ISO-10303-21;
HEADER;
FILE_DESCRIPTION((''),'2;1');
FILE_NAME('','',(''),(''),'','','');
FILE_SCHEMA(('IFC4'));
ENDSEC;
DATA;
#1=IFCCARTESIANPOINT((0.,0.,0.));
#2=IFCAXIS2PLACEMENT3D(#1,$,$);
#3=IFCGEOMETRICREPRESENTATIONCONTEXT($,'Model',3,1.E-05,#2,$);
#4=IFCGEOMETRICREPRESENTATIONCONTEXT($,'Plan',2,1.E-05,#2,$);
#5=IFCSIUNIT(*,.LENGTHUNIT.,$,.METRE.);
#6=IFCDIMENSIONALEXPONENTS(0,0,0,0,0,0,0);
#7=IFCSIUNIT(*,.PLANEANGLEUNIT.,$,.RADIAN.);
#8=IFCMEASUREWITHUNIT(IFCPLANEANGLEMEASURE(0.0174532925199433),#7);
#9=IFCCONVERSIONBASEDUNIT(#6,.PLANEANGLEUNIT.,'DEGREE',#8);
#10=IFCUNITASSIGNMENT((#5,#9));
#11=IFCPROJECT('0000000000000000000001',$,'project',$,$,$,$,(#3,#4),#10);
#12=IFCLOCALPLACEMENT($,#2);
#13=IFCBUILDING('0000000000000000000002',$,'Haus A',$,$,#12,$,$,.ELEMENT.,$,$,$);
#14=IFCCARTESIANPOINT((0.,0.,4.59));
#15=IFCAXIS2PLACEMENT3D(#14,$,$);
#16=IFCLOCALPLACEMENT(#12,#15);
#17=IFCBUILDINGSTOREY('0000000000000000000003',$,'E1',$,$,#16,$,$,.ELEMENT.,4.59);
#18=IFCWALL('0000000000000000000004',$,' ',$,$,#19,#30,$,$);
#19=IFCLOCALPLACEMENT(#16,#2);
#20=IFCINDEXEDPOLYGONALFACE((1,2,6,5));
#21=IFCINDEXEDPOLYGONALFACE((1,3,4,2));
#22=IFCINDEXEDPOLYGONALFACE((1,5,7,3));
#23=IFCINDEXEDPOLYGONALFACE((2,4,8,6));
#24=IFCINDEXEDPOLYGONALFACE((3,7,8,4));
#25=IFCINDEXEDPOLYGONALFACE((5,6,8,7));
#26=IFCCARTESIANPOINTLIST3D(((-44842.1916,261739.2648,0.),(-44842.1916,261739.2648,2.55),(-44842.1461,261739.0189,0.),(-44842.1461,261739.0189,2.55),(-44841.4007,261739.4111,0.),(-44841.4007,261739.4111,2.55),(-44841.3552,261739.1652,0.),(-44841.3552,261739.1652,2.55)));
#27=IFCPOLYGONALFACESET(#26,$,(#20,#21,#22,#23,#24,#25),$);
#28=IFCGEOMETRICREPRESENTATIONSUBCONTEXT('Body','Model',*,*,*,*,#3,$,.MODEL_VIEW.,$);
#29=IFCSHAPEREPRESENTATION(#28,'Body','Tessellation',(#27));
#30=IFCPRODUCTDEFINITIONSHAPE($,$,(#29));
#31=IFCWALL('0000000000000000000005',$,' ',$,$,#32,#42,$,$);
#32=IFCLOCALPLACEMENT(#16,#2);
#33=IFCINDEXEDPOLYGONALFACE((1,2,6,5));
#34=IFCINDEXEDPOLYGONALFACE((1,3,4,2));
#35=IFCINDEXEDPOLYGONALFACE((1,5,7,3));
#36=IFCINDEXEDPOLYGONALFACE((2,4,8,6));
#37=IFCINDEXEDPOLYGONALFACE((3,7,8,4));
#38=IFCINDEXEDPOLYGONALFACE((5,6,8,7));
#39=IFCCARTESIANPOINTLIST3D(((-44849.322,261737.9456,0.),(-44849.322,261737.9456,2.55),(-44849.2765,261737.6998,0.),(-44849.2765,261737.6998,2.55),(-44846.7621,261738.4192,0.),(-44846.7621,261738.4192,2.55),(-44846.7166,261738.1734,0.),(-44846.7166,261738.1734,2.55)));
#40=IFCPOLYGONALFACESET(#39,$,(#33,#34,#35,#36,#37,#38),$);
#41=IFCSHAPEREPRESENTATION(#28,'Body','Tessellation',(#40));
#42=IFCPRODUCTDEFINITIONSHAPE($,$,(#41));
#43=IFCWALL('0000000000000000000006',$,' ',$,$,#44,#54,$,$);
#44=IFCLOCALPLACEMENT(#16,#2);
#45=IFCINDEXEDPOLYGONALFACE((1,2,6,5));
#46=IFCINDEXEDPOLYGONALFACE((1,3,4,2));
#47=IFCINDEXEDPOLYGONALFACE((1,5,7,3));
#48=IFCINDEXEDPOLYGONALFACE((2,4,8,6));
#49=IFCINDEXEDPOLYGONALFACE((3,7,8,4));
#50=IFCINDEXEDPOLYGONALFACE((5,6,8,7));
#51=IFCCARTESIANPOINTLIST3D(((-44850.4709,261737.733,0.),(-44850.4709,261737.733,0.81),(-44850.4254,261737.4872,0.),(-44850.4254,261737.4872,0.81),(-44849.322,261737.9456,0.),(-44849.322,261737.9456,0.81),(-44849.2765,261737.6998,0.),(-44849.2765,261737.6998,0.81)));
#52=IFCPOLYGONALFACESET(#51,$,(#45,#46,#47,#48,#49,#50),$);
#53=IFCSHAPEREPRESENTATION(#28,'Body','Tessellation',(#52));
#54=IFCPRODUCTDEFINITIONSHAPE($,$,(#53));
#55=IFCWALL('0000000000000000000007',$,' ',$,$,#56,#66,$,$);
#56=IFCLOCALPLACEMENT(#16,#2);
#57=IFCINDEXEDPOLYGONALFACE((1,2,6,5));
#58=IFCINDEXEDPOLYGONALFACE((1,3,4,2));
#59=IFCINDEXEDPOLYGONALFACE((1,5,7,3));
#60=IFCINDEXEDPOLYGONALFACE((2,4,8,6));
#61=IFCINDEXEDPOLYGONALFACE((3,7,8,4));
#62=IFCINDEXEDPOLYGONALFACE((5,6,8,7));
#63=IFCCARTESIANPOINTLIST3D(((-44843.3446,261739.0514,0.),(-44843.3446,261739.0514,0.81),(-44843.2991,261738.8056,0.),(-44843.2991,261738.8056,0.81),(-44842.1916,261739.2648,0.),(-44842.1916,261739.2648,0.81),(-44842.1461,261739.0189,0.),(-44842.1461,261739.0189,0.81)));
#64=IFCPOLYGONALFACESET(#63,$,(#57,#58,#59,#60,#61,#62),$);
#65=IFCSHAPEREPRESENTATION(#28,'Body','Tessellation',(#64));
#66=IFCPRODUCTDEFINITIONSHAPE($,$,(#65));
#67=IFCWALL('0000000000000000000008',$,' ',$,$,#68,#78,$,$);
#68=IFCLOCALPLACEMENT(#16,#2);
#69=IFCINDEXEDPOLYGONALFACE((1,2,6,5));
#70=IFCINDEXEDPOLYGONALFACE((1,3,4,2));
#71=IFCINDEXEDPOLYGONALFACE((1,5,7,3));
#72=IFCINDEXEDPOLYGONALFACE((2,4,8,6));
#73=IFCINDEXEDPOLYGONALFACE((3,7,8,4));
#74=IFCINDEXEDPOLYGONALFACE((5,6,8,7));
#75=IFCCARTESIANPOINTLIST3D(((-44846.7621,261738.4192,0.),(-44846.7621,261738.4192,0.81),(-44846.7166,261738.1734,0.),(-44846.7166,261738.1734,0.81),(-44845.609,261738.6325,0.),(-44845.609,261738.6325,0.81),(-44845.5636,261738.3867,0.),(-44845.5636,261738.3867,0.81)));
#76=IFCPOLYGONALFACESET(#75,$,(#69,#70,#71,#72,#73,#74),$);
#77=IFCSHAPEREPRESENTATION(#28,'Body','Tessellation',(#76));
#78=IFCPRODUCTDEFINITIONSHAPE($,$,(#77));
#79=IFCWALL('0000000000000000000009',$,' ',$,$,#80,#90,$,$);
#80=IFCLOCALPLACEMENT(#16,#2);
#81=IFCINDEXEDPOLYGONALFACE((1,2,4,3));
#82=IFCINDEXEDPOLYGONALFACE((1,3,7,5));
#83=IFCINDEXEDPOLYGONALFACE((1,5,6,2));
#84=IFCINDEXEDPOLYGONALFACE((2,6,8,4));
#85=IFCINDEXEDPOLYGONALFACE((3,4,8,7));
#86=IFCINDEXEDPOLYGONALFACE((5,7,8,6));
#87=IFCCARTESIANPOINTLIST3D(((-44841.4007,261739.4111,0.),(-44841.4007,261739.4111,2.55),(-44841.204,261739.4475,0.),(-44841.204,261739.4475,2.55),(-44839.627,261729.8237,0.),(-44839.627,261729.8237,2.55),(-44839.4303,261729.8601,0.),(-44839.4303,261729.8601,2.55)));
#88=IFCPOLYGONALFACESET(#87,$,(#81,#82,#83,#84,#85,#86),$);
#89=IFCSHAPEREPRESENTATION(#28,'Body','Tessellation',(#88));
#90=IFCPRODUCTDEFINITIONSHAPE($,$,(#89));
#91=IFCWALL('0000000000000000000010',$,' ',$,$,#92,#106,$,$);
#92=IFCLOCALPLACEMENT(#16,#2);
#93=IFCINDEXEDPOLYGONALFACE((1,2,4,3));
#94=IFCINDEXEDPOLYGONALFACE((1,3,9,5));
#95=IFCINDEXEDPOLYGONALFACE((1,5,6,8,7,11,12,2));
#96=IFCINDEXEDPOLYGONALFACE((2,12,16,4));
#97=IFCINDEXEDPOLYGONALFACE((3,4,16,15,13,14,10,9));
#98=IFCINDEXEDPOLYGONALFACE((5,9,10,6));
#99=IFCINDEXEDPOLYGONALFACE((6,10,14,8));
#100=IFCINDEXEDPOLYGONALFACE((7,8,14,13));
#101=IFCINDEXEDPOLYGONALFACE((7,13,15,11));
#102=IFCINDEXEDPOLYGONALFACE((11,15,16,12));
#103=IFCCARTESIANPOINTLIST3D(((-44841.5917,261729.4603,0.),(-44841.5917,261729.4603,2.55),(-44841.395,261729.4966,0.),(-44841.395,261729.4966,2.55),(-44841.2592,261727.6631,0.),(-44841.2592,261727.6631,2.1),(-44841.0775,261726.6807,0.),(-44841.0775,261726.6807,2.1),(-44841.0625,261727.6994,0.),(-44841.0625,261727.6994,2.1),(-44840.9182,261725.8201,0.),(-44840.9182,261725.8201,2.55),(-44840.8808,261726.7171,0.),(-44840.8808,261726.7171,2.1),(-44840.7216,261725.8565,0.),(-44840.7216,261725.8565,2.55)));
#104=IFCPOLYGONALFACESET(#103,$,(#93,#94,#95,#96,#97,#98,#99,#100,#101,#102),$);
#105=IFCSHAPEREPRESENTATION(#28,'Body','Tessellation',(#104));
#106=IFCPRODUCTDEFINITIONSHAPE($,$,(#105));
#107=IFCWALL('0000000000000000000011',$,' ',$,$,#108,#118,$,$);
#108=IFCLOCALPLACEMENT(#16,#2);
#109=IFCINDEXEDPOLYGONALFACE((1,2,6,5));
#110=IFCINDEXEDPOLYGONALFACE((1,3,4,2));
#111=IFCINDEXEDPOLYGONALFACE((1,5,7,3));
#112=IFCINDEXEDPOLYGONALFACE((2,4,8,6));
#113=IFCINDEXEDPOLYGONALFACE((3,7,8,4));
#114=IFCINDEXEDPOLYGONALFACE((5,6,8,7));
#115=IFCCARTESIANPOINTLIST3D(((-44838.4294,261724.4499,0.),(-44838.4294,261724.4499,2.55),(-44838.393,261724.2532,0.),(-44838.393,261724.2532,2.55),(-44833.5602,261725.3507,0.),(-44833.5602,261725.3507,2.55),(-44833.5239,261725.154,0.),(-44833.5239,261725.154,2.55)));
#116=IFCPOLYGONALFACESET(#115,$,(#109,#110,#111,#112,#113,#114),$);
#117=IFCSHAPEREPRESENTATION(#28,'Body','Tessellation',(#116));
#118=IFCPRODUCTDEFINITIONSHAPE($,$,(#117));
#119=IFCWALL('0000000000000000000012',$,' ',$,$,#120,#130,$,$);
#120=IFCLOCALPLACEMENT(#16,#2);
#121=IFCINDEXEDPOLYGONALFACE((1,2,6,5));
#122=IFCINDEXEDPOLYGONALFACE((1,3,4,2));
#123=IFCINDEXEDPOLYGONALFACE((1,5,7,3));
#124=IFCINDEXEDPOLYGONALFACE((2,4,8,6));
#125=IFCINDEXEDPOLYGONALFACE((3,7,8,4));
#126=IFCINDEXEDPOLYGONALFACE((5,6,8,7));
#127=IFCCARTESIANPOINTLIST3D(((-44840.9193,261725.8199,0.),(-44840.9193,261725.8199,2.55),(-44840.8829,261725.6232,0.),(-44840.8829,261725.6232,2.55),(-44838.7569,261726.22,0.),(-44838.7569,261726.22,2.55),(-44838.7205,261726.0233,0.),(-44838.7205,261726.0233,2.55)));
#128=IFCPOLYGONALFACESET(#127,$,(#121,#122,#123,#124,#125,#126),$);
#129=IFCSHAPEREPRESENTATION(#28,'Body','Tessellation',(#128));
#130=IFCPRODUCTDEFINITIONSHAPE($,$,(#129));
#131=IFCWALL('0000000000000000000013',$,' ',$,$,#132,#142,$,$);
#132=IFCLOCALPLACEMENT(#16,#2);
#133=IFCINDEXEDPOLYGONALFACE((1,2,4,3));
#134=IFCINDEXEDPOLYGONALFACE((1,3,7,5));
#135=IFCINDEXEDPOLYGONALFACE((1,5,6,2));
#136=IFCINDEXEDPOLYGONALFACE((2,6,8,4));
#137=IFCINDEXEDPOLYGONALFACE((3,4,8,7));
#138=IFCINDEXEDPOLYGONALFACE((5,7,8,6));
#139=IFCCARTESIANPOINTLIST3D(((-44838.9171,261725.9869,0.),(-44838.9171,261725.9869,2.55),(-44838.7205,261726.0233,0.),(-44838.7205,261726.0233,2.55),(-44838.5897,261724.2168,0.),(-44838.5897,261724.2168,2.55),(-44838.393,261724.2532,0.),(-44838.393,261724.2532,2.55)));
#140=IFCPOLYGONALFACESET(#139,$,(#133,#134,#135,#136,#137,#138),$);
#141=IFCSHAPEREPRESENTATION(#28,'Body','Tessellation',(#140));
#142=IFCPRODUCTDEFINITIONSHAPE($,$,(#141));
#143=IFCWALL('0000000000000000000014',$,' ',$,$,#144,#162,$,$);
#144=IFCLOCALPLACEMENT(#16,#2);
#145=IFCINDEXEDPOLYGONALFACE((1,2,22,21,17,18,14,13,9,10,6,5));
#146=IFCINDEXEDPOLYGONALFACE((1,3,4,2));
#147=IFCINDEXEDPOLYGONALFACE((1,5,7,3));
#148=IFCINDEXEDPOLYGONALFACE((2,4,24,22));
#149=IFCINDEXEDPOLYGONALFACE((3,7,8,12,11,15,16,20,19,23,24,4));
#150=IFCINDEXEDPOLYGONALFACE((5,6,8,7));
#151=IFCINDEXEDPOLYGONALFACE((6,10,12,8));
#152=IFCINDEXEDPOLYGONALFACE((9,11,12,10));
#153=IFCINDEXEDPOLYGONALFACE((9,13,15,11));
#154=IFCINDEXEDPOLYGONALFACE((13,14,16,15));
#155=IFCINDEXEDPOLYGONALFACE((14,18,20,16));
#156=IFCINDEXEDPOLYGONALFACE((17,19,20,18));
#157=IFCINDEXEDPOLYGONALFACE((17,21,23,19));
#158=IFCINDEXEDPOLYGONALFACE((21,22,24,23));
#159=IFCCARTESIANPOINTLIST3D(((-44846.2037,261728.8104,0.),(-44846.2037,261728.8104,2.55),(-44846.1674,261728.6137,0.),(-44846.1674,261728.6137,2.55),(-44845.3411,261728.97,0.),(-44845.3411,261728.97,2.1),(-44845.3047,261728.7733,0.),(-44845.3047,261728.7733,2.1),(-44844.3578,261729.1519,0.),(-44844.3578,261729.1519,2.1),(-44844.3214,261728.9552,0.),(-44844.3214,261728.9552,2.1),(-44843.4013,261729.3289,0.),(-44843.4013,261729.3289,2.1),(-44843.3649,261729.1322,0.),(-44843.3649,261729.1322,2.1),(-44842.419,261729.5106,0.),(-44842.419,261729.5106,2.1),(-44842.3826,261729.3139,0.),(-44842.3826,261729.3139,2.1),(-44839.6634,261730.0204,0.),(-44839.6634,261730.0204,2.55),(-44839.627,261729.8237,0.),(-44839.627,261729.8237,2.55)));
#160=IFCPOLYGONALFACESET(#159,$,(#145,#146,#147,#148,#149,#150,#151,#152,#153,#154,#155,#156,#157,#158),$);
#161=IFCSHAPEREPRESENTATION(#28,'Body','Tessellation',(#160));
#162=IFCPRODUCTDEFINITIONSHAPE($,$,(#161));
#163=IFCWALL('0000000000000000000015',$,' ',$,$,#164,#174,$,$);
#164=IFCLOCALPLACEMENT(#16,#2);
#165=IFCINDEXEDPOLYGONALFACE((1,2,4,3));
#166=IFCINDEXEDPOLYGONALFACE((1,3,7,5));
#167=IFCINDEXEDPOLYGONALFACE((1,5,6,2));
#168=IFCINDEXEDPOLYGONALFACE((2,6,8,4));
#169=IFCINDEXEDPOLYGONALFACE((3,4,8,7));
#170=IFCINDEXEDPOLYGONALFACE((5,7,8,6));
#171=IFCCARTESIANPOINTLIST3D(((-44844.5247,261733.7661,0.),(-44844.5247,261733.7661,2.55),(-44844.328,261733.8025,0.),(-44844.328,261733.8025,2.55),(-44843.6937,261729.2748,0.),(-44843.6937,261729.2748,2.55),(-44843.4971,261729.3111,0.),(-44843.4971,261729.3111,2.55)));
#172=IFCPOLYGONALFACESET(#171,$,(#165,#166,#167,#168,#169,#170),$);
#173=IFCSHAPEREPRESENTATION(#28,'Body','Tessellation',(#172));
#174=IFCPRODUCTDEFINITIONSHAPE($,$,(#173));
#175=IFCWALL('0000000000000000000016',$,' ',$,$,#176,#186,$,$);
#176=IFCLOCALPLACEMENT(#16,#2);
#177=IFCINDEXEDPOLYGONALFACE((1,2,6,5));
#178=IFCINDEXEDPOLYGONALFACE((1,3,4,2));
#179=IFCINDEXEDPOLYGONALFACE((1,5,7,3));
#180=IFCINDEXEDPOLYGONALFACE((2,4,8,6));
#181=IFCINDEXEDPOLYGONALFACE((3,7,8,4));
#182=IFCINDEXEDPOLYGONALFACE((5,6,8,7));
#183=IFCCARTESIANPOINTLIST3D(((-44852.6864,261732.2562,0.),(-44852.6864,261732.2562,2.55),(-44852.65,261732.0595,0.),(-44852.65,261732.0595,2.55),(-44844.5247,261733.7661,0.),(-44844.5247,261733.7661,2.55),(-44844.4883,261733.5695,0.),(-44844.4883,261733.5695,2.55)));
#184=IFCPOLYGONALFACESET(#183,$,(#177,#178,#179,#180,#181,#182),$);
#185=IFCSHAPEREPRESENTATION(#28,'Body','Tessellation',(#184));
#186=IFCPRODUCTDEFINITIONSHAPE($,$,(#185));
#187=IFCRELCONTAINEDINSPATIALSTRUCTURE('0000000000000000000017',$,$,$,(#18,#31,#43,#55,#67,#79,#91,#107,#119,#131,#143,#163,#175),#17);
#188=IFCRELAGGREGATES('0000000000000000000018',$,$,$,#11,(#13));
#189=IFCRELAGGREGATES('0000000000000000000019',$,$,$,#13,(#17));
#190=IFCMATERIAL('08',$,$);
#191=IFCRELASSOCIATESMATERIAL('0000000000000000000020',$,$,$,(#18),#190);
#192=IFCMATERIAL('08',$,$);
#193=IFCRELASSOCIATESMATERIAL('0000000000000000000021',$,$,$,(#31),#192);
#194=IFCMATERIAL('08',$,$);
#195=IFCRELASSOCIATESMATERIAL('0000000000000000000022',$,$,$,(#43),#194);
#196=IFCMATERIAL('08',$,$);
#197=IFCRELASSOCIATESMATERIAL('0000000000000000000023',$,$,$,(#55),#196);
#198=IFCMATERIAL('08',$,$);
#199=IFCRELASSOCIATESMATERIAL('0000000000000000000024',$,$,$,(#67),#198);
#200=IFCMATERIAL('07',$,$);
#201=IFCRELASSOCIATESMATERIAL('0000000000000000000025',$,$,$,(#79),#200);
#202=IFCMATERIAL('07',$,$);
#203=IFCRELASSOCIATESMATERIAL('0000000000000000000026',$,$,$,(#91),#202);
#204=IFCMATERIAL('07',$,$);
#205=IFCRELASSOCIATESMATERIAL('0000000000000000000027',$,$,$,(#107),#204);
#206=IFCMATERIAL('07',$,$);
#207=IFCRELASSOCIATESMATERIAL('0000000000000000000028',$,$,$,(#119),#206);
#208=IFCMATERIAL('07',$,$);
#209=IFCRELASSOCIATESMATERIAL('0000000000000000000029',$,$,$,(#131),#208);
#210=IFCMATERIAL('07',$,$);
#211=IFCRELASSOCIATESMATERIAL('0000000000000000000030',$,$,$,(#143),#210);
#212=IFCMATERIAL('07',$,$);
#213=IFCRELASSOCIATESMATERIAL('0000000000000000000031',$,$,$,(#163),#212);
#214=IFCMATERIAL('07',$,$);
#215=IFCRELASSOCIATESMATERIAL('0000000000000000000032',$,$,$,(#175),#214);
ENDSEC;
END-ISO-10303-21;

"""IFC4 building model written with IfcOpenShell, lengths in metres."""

from ifc_helpers import new_model, entity, si_unit, converted_unit, frame, frame_2d, origin, origin_with_axes, place, context, subcontext, project, spatial, polyline, rectangle, outline, extrude, material, element, save


model = new_model("IFC4")

# Units and contexts
model_context = context("Model", 3, precision=1e-05, world=origin())
plan_context = context("Plan", 2, precision=1e-05, world=origin())
body_context = subcontext(model_context, "Body", "Model", "MODEL_VIEW")
ifc_project = project(units=[si_unit("LENGTHUNIT", "METRE"), converted_unit("PLANEANGLEUNIT", "DEGREE", entity("IfcPlaneAngleMeasure", 0.0174532925199433), si_unit("PLANEANGLEUNIT", "RADIAN"), dimensions=[0, 0, 0, 0, 0, 0, 0])], contexts=[model_context, plan_context])

# Building, storey
building_placement = place(None, origin())
building = spatial("IfcBuilding", under=ifc_project, at=building_placement, Name="Haus A", CompositionType="ELEMENT")
storey_placement = place(building_placement, frame((0.0, 0.0, 4.59)))
storey = spatial("IfcBuildingStorey", under=building, at=storey_placement, Name="E1", CompositionType="ELEMENT", Elevation=4.59)

# Walls
ifc_material_1 = material(Name="08")
wall_1_placement = place(storey_placement, frame((-44841.4007, 261739.4111, 0.0), z_axis=(0.0, 0.0, 1.0), x_axis=(-0.983313, -0.18192, 0.0)))
element("IfcWall", 1, at=wall_1_placement, inside=storey, material=ifc_material_1, Name=" ", context=body_context, shape_type="SweptSolid", body=[
    extrude(rectangle(XDim=0.8043, YDim=0.25, at=frame_2d((0.4022, 0.125), x_axis=(1.0, 0.0))), origin_with_axes(), (0.0, 0.0, 1.0), 2.55),
])
ifc_material_2 = material(Name="08")
wall_2_placement = place(storey_placement, frame((-44846.7621, 261738.4192, 0.0), z_axis=(0.0, 0.0, 1.0), x_axis=(-0.983313, -0.18192, 0.0)))
element("IfcWall", 2, at=wall_2_placement, inside=storey, material=ifc_material_2, Name=" ", context=body_context, shape_type="SweptSolid", body=[
    extrude(rectangle(XDim=2.6034, YDim=0.25, at=frame_2d((1.3017, 0.125), x_axis=(1.0, 0.0))), origin_with_axes(), (0.0, 0.0, 1.0), 2.55),
])
ifc_material_3 = material(Name="08")
wall_3_placement = place(storey_placement, frame((-44849.322, 261737.9456, 0.0), z_axis=(0.0, 0.0, 1.0), x_axis=(-0.983313, -0.18192, 0.0)))
element("IfcWall", 3, at=wall_3_placement, inside=storey, material=ifc_material_3, Name=" ", context=body_context, shape_type="SweptSolid", body=[
    extrude(rectangle(XDim=1.1684, YDim=0.25, at=frame_2d((0.5842, 0.125), x_axis=(1.0, 0.0))), origin_with_axes(), (0.0, 0.0, 1.0), 0.81),
])
ifc_material_4 = material(Name="08")
wall_4_placement = place(storey_placement, frame((-44842.1916, 261739.2648, 0.0), z_axis=(0.0, 0.0, 1.0), x_axis=(-0.983313, -0.18192, 0.0)))
element("IfcWall", 4, at=wall_4_placement, inside=storey, material=ifc_material_4, Name=" ", context=body_context, shape_type="SweptSolid", body=[
    extrude(rectangle(XDim=1.1726, YDim=0.25, at=frame_2d((0.5863, 0.125), x_axis=(1.0, 0.0))), origin_with_axes(), (0.0, 0.0, 1.0), 0.81),
])
ifc_material_5 = material(Name="08")
wall_5_placement = place(storey_placement, frame((-44845.609, 261738.6325, 0.0), z_axis=(0.0, 0.0, 1.0), x_axis=(-0.983313, -0.18192, 0.0)))
element("IfcWall", 5, at=wall_5_placement, inside=storey, material=ifc_material_5, Name=" ", context=body_context, shape_type="SweptSolid", body=[
    extrude(rectangle(XDim=1.1726, YDim=0.25, at=frame_2d((0.5863, 0.125), x_axis=(1.0, 0.0))), origin_with_axes(), (0.0, 0.0, 1.0), 0.81),
])
ifc_material_6 = material(Name="07")
wall_6_placement = place(storey_placement, frame((-44841.4007, 261739.4111, 0.0), z_axis=(0.0, 0.0, 1.0), x_axis=(0.18192, -0.983313, 0.0)))
element("IfcWall", 6, at=wall_6_placement, inside=storey, material=ifc_material_6, Name=" ", context=body_context, shape_type="SweptSolid", body=[
    extrude(rectangle(XDim=9.75, YDim=0.2, at=frame_2d((4.875, 0.1), x_axis=(1.0, 0.0))), origin_with_axes(), (0.0, 0.0, 1.0), 2.55),
])

# Wall, opening
ifc_material_7 = material(Name="07")
wall_7_placement = place(storey_placement, frame((-44841.5917, 261729.4603, 0.0), z_axis=(0.0, 0.0, 1.0), x_axis=(0.18192, -0.983313, 0.0)))
wall_7 = element("IfcWall", 7, at=wall_7_placement, inside=storey, material=ifc_material_7, Name=" ", context=body_context, shape_type="SweptSolid", body=[
    extrude(rectangle(XDim=3.7019, YDim=0.2, at=frame_2d((1.851, 0.1), x_axis=(1.0, 0.0))), origin_with_axes(), (0.0, 0.0, 1.0), 2.55),
])
opening_1_placement = place(wall_7_placement, frame((2.8267, 0.2, 0.0), z_axis=(0.0, -1.0, 0.0), x_axis=(0.0, 0.0, 1.0)))
element("IfcOpeningElement", 8, at=opening_1_placement, cuts=wall_7, ObjectType="Opening", context=body_context, shape_type="SweptSolid", body=[
    extrude(outline(polyline([(0.0, 0.999), (2.1, 0.999), (2.1, 0.0), (0.0, 0.0), (0.0, 0.999)])), origin_with_axes(), (0.0, 0.0, 1.0), 0.2),
])

# Walls
ifc_material_8 = material(Name="07")
wall_8_placement = place(storey_placement, frame((-44833.5602, 261725.3507, 0.0), z_axis=(0.0, 0.0, 1.0), x_axis=(-0.983313, -0.18192, 0.0)))
element("IfcWall", 9, at=wall_8_placement, inside=storey, material=ifc_material_8, Name=" ", context=body_context, shape_type="SweptSolid", body=[
    extrude(rectangle(XDim=4.9518, YDim=0.2, at=frame_2d((2.4759, 0.1), x_axis=(1.0, 0.0))), origin_with_axes(), (0.0, 0.0, 1.0), 2.55),
])
ifc_material_9 = material(Name="07")
wall_9_placement = place(storey_placement, frame((-44840.8829, 261725.6232, 0.0), z_axis=(0.0, 0.0, 1.0), x_axis=(0.983313, 0.18192, 0.0)))
element("IfcWall", 10, at=wall_9_placement, inside=storey, material=ifc_material_9, Name=" ", context=body_context, shape_type="SweptSolid", body=[
    extrude(rectangle(XDim=2.1991, YDim=0.2, at=frame_2d((1.0995, 0.1), x_axis=(1.0, 0.0))), origin_with_axes(), (0.0, 0.0, 1.0), 2.55),
])
ifc_material_10 = material(Name="07")
wall_10_placement = place(storey_placement, frame((-44838.9171, 261725.9869, 0.0), z_axis=(0.0, 0.0, 1.0), x_axis=(0.18192, -0.983313, 0.0)))
element("IfcWall", 11, at=wall_10_placement, inside=storey, material=ifc_material_10, Name=" ", context=body_context, shape_type="SweptSolid", body=[
    extrude(rectangle(XDim=1.8001, YDim=0.2, at=frame_2d((0.9001, 0.1), x_axis=(1.0, 0.0))), origin_with_axes(), (0.0, 0.0, 1.0), 2.55),
])

# Wall, openings
ifc_material_11 = material(Name="07")
wall_11_placement = place(storey_placement, frame((-44839.6634, 261730.0204, 0.0), z_axis=(0.0, 0.0, 1.0), x_axis=(-0.983313, -0.18192, 0.0)))
wall_11 = element("IfcWall", 12, at=wall_11_placement, inside=storey, material=ifc_material_11, Name=" ", context=body_context, shape_type="SweptSolid", body=[
    extrude(rectangle(XDim=6.6514, YDim=0.2, at=frame_2d((3.3257, 0.1), x_axis=(1.0, 0.0))), origin_with_axes(), (0.0, 0.0, 1.0), 2.55),
])
opening_2_placement = place(wall_11_placement, frame((2.8023, 0.0, 0.0), z_axis=(0.0, 1.0, 0.0), x_axis=(0.0, 0.0, 1.0)))
element("IfcOpeningElement", 13, at=opening_2_placement, cuts=wall_11, ObjectType="Opening", context=body_context, shape_type="SweptSolid", body=[
    extrude(outline(polyline([(0.0, 0.999), (2.1, 0.999), (2.1, 0.0), (0.0, 0.0), (0.0, 0.999)])), origin_with_axes(), (0.0, 0.0, 1.0), 0.2),
])
opening_3_placement = place(wall_11_placement, frame((4.774, 0.0, 0.0), z_axis=(0.0, 1.0, 0.0), x_axis=(0.0, 0.0, 1.0)))
element("IfcOpeningElement", 14, at=opening_3_placement, cuts=wall_11, ObjectType="Opening", context=body_context, shape_type="SweptSolid", body=[
    extrude(outline(polyline([(0.0, 0.0), (0.0, 1.0), (2.1, 1.0), (2.1, 0.0), (0.0, 0.0)])), origin_with_axes(), (0.0, 0.0, 1.0), 0.2),
])

# Walls
ifc_material_12 = material(Name="07")
wall_12_placement = place(storey_placement, frame((-44843.4971, 261729.3111, 0.0), z_axis=(0.0, 0.0, 1.0), x_axis=(-0.18192, 0.983313, 0.0)))
element("IfcWall", 15, at=wall_12_placement, inside=storey, material=ifc_material_12, Name=" ", context=body_context, shape_type="SweptSolid", body=[
    extrude(rectangle(XDim=4.5676, YDim=0.2, at=frame_2d((2.2838, 0.1), x_axis=(1.0, 0.0))), origin_with_axes(), (0.0, 0.0, 1.0), 2.55),
])
ifc_material_13 = material(Name="07")
wall_13_placement = place(storey_placement, frame((-44844.5247, 261733.7661, 0.0), z_axis=(0.0, 0.0, 1.0), x_axis=(-0.983313, -0.18192, 0.0)))
element("IfcWall", 16, at=wall_13_placement, inside=storey, material=ifc_material_13, Name=" ", context=body_context, shape_type="SweptSolid", body=[
    extrude(rectangle(XDim=8.3002, YDim=0.2, at=frame_2d((4.1501, 0.1), x_axis=(1.0, 0.0))), origin_with_axes(), (0.0, 0.0, 1.0), 2.55),
])

save(model, "model.ifc")
